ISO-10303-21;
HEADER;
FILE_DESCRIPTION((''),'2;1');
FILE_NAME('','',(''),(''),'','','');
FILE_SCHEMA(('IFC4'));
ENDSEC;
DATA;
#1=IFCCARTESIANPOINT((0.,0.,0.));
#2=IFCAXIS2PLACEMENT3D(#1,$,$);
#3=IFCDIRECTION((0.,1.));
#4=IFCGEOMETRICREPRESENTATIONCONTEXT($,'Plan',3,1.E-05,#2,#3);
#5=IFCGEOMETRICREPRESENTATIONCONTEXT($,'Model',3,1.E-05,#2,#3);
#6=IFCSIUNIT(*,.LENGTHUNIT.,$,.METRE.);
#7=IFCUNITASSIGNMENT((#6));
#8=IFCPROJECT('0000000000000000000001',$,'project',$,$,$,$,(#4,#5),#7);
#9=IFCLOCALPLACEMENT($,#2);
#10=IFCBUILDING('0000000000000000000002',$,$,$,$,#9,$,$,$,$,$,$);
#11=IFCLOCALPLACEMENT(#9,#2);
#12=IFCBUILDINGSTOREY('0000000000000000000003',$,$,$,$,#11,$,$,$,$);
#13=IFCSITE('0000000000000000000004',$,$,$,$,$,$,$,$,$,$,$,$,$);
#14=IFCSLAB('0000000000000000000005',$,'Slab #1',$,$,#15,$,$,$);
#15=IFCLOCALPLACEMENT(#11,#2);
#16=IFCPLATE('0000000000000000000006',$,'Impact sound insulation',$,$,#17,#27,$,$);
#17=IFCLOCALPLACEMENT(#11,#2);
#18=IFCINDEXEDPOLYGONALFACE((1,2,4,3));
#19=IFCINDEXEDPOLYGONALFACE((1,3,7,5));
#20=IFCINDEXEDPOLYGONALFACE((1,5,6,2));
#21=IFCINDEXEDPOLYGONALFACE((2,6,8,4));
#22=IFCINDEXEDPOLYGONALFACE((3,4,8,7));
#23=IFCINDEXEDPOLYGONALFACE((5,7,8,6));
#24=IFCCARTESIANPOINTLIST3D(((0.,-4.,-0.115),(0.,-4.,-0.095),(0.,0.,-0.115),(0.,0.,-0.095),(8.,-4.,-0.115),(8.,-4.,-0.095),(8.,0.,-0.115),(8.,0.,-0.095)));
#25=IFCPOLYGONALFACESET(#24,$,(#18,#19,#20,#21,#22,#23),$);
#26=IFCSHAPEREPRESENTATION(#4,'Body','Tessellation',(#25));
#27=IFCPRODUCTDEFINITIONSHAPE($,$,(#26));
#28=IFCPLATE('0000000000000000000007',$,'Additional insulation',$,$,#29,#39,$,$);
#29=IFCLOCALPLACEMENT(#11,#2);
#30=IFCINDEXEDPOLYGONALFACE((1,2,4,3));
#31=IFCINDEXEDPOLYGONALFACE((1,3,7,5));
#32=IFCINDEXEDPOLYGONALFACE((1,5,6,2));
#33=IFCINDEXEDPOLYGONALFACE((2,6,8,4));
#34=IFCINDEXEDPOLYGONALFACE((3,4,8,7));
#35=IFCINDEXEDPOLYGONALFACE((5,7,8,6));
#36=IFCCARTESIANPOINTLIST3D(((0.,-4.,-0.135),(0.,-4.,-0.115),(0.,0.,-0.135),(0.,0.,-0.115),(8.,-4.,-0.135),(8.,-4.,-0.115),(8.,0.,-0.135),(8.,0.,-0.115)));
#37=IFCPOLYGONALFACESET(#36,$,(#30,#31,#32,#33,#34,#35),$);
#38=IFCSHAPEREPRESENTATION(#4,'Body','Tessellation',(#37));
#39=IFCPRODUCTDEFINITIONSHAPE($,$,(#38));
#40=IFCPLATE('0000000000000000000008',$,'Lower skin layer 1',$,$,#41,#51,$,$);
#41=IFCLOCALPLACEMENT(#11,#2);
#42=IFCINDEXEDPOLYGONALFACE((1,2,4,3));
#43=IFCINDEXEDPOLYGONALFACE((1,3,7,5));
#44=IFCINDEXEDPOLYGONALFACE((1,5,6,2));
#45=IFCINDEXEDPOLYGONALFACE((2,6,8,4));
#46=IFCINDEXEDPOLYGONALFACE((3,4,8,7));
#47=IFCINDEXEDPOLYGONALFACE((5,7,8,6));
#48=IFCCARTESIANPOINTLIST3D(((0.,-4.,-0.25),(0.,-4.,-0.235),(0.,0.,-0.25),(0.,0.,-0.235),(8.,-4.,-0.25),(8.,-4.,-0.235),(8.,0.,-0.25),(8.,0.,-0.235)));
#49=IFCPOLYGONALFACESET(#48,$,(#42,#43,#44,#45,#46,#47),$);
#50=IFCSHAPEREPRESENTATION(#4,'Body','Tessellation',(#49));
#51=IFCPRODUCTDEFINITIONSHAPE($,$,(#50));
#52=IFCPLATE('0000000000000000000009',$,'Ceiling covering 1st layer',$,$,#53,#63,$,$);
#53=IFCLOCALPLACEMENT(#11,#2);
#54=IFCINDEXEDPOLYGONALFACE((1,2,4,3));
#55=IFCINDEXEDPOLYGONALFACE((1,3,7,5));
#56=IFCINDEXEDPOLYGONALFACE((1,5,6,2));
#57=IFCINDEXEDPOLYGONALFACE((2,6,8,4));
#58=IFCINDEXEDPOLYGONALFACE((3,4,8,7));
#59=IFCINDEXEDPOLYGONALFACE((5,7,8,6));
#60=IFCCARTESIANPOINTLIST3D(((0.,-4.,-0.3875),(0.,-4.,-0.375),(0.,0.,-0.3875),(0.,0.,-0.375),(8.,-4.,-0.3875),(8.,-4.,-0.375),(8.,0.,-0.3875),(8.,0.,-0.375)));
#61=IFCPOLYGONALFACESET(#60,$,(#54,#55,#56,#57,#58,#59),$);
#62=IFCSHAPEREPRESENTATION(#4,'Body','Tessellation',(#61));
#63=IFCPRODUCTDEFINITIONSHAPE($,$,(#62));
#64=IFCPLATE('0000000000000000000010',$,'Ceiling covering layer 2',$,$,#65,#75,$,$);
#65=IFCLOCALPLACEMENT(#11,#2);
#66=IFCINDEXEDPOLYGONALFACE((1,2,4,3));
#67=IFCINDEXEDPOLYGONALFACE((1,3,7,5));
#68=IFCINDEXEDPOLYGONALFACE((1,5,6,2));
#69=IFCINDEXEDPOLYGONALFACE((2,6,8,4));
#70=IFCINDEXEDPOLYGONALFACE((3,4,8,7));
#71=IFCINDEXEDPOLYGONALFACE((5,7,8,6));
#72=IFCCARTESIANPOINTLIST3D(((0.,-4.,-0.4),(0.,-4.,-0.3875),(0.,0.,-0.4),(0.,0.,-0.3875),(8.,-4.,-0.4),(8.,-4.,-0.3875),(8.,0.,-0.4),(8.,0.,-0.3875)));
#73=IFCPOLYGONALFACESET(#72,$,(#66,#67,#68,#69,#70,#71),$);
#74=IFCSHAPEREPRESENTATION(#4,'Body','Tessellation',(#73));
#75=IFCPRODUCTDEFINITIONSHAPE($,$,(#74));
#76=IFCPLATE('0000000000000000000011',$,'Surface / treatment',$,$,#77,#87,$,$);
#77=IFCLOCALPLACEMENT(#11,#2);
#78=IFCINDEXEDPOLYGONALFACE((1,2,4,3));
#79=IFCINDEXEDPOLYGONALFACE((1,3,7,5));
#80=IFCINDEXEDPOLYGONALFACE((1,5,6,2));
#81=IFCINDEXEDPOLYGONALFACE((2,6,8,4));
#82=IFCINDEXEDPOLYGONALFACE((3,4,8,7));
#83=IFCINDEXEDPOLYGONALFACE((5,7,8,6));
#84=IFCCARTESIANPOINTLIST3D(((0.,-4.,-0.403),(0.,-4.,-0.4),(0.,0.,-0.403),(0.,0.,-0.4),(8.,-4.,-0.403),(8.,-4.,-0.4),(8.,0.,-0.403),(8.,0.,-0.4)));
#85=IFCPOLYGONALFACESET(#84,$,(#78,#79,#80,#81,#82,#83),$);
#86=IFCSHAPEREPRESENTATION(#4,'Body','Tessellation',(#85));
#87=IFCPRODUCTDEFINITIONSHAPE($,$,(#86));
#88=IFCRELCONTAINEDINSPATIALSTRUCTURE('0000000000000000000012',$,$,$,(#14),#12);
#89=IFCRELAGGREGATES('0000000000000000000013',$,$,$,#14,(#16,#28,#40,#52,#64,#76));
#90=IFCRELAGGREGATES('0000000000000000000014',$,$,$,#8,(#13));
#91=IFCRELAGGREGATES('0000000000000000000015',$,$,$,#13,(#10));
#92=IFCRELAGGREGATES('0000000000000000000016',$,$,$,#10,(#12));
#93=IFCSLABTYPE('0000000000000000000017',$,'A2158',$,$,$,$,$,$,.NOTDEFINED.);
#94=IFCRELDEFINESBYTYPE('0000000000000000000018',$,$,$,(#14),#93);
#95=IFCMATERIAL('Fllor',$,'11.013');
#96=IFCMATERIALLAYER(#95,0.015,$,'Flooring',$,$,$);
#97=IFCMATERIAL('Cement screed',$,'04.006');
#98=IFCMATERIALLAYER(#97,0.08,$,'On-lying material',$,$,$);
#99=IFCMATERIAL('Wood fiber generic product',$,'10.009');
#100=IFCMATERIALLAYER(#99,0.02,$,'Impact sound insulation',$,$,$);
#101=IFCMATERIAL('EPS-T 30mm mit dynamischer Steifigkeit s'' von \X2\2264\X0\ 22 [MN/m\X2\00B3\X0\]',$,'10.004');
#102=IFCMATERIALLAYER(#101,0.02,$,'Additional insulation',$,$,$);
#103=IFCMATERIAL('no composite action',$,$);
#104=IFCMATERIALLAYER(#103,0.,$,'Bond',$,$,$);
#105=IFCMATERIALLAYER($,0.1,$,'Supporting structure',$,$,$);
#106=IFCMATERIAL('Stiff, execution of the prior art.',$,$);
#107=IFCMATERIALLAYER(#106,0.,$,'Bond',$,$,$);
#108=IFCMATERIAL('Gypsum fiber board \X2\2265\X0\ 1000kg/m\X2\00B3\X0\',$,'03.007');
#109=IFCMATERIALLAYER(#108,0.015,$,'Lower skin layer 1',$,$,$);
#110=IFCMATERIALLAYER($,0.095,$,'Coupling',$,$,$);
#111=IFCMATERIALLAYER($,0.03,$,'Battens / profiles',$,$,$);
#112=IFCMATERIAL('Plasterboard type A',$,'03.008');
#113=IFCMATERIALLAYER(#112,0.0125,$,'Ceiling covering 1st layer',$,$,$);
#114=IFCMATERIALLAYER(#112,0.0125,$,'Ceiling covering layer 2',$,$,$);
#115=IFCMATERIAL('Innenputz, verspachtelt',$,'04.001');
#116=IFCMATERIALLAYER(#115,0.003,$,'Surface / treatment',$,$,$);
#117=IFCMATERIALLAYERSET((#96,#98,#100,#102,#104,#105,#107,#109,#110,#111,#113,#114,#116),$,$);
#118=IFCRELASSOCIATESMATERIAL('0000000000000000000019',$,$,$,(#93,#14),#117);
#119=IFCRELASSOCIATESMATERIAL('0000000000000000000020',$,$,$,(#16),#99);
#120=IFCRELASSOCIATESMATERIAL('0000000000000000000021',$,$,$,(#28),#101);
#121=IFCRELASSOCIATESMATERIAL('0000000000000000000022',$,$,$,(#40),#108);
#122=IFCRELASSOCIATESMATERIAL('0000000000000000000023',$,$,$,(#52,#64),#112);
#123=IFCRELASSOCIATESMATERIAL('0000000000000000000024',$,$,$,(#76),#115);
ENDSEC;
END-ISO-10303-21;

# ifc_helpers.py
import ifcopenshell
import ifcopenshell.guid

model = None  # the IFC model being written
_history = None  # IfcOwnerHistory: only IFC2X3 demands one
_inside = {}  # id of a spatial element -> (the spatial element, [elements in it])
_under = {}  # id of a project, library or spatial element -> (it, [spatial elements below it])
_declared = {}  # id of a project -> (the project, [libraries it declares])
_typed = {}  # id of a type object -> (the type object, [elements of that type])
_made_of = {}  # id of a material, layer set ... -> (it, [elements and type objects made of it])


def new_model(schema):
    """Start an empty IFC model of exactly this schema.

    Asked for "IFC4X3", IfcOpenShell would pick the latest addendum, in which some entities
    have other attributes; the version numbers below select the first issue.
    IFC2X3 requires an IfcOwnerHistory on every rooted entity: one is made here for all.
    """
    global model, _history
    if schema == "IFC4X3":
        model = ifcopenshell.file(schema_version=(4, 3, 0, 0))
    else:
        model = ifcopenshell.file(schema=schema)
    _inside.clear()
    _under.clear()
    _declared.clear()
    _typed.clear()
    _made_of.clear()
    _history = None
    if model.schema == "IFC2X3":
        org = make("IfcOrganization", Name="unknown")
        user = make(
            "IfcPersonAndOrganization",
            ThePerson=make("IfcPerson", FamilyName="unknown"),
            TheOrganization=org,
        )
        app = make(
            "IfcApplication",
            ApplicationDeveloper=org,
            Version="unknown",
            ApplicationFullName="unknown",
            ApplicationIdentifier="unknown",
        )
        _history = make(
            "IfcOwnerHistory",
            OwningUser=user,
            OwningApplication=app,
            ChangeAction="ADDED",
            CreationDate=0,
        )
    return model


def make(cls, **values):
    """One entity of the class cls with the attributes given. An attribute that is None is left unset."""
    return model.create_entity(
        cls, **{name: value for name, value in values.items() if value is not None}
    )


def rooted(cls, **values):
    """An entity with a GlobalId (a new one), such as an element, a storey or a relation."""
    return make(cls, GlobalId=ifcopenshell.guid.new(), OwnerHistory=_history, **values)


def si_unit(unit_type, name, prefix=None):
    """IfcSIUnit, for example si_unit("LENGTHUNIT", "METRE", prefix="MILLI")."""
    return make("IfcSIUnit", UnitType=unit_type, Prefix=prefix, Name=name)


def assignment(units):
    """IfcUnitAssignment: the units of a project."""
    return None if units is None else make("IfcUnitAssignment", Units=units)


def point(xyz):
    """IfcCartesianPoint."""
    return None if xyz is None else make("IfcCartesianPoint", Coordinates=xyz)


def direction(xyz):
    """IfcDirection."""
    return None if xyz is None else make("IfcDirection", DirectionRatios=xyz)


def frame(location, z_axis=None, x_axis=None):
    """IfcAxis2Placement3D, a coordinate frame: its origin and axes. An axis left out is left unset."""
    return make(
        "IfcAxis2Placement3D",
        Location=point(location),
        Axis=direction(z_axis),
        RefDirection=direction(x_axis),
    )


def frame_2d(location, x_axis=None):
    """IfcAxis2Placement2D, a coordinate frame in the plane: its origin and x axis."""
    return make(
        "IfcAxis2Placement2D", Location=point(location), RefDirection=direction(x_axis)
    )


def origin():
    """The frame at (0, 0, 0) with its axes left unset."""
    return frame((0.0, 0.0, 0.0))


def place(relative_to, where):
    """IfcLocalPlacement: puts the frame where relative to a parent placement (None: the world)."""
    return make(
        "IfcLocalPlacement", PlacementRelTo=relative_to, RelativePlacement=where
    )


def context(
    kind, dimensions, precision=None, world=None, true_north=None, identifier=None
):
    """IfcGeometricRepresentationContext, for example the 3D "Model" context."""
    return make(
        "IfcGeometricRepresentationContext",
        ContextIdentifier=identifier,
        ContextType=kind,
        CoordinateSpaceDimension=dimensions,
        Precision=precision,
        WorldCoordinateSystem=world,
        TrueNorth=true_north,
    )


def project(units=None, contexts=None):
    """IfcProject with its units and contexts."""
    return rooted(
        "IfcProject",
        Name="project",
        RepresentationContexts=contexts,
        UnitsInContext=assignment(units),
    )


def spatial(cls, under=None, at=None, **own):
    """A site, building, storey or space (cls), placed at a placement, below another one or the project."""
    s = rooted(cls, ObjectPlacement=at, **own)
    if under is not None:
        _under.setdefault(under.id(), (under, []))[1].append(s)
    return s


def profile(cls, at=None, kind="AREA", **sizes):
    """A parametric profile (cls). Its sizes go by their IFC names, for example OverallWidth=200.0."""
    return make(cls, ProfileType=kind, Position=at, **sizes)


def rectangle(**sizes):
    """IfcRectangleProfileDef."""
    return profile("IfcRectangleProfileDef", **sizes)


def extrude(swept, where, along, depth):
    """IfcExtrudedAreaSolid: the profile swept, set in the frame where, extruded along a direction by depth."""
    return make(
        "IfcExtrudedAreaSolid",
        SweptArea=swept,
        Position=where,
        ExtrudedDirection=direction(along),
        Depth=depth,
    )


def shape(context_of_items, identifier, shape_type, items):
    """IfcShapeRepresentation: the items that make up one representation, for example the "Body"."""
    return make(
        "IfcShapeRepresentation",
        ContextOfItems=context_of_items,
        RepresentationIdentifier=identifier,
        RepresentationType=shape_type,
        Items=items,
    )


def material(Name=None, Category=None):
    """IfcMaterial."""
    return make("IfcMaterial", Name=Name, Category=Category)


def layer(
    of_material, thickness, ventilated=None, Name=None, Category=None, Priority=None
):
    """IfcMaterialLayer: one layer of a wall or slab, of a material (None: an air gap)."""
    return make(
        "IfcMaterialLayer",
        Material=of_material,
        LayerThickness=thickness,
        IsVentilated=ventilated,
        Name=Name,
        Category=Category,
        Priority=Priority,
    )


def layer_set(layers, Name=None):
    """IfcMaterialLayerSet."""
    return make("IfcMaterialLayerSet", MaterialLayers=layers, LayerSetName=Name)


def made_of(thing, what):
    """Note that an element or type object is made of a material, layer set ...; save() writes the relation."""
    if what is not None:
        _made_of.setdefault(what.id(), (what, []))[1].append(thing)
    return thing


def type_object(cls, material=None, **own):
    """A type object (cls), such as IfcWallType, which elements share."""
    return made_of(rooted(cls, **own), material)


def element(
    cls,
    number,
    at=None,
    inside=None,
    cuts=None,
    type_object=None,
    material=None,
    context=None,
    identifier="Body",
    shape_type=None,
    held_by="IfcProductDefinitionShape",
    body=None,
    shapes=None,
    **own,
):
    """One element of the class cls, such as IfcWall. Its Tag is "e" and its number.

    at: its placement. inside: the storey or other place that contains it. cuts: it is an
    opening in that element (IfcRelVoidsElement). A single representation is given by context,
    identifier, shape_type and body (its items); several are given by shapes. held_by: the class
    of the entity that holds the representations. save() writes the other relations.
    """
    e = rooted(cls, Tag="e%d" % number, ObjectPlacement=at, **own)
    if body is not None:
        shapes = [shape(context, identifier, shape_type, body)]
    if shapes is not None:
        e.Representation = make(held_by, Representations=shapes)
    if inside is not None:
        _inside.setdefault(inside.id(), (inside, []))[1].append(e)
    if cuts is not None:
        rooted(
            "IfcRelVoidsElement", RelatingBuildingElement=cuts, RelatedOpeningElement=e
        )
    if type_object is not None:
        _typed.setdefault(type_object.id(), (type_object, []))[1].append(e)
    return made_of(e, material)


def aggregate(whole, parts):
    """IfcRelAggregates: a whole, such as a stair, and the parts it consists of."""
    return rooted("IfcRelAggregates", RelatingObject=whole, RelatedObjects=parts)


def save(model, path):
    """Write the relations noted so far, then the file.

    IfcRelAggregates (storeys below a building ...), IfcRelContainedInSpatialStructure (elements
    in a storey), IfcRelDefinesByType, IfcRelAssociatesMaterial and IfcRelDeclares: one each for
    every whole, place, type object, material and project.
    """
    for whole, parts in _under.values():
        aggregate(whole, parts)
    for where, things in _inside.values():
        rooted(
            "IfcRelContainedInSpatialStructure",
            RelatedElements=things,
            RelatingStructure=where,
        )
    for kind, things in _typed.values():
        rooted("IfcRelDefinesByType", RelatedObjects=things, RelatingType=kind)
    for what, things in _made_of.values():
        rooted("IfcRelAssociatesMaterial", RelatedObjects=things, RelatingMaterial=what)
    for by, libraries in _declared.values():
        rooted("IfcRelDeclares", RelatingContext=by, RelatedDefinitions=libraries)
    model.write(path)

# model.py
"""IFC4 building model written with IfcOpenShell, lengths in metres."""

from ifc_helpers import new_model, si_unit, direction, frame, frame_2d, origin, place, context, project, spatial, rectangle, extrude, material, layer, layer_set, type_object, element, aggregate, save


model = new_model("IFC4")

# Units and contexts
plan_context = context("Plan", 3, precision=1e-05, world=origin(), true_north=direction((0.0, 1.0)))
model_context = context("Model", 3, precision=1e-05, world=origin(), true_north=direction((0.0, 1.0)))
ifc_project = project(units=[si_unit("LENGTHUNIT", "METRE")], contexts=[plan_context, model_context])

# Site, building, storey
site = spatial("IfcSite", under=ifc_project)
building_placement = place(None, origin())
building = spatial("IfcBuilding", under=site, at=building_placement)
storey_placement = place(building_placement, origin())
storey = spatial("IfcBuildingStorey", under=building, at=storey_placement)

# Slab, plates
ifc_material_1 = material(Name="Fllor", Category="11.013")
ifc_layer_1 = layer(ifc_material_1, 0.015, Name="Flooring")
ifc_material_2 = material(Name="Cement screed", Category="04.006")
ifc_layer_2 = layer(ifc_material_2, 0.08, Name="On-lying material")
ifc_material_3 = material(Name="Wood fiber generic product", Category="10.009")
ifc_layer_3 = layer(ifc_material_3, 0.02, Name="Impact sound insulation")
ifc_material_4 = material(Name="EPS-T 30mm mit dynamischer Steifigkeit s' von ≤ 22 [MN/m³]", Category="10.004")
ifc_layer_4 = layer(ifc_material_4, 0.02, Name="Additional insulation")
ifc_material_5 = material(Name="no composite action")
ifc_layer_5 = layer(ifc_material_5, 0.0, Name="Bond")
ifc_layer_6 = layer(None, 0.1, Name="Supporting structure")
ifc_material_6 = material(Name="Stiff, execution of the prior art.")
ifc_layer_7 = layer(ifc_material_6, 0.0, Name="Bond")
ifc_material_7 = material(Name="Gypsum fiber board ≥ 1000kg/m³", Category="03.007")
ifc_layer_8 = layer(ifc_material_7, 0.015, Name="Lower skin layer 1")
ifc_layer_9 = layer(None, 0.095, Name="Coupling")
ifc_layer_10 = layer(None, 0.03, Name="Battens / profiles")
ifc_material_8 = material(Name="Plasterboard type A", Category="03.008")
ifc_layer_11 = layer(ifc_material_8, 0.0125, Name="Ceiling covering 1st layer")
ifc_layer_12 = layer(ifc_material_8, 0.0125, Name="Ceiling covering layer 2")
ifc_material_9 = material(Name="Innenputz, verspachtelt", Category="04.001")
ifc_layer_13 = layer(ifc_material_9, 0.003, Name="Surface / treatment")
ifc_layer_set = layer_set([ifc_layer_1, ifc_layer_2, ifc_layer_3, ifc_layer_4, ifc_layer_5, ifc_layer_6, ifc_layer_7, ifc_layer_8, ifc_layer_9, ifc_layer_10, ifc_layer_11, ifc_layer_12, ifc_layer_13])
slab_type = type_object("IfcSlabType", Name="A2158", PredefinedType="NOTDEFINED", material=ifc_layer_set)
slab_placement = place(None, frame((0.0, 0.0, 0.0), z_axis=(0.0, 0.0, -1.0), x_axis=(1.0, 0.0, 0.0)))
slab = element("IfcSlab", 1, at=slab_placement, inside=storey, type_object=slab_type, material=ifc_layer_set, Name="Slab #1")
plate_1_placement = place(slab_placement, origin())
plate_1 = element("IfcPlate", 2, at=plate_1_placement, material=ifc_material_3, Name="Impact sound insulation", context=plan_context, shape_type="SweptSolid", body=[
    extrude(rectangle(XDim=8.0, YDim=4.0, at=frame_2d((4.0, 2.0), x_axis=(1.0, 0.0))), frame((0.0, 0.0, 0.095), z_axis=(0.0, 0.0, 1.0), x_axis=(1.0, 0.0, 0.0)), (0.0, 0.0, 1.0), 0.02),
])
plate_2_placement = place(slab_placement, origin())
plate_2 = element("IfcPlate", 3, at=plate_2_placement, material=ifc_material_4, Name="Additional insulation", context=plan_context, shape_type="SweptSolid", body=[
    extrude(rectangle(XDim=8.0, YDim=4.0, at=frame_2d((4.0, 2.0), x_axis=(1.0, 0.0))), frame((0.0, 0.0, 0.115), z_axis=(0.0, 0.0, 1.0), x_axis=(1.0, 0.0, 0.0)), (0.0, 0.0, 1.0), 0.02),
])
plate_3_placement = place(slab_placement, origin())
plate_3 = element("IfcPlate", 4, at=plate_3_placement, material=ifc_material_7, Name="Lower skin layer 1", context=plan_context, shape_type="SweptSolid", body=[
    extrude(rectangle(XDim=8.0, YDim=4.0, at=frame_2d((4.0, 2.0), x_axis=(1.0, 0.0))), frame((0.0, 0.0, 0.235), z_axis=(0.0, 0.0, 1.0), x_axis=(1.0, 0.0, 0.0)), (0.0, 0.0, 1.0), 0.015),
])
plate_4_placement = place(slab_placement, origin())
plate_4 = element("IfcPlate", 5, at=plate_4_placement, material=ifc_material_8, Name="Ceiling covering 1st layer", context=plan_context, shape_type="SweptSolid", body=[
    extrude(rectangle(XDim=8.0, YDim=4.0, at=frame_2d((4.0, 2.0), x_axis=(1.0, 0.0))), frame((0.0, 0.0, 0.375), z_axis=(0.0, 0.0, 1.0), x_axis=(1.0, 0.0, 0.0)), (0.0, 0.0, 1.0), 0.0125),
])
plate_5_placement = place(slab_placement, origin())
plate_5 = element("IfcPlate", 6, at=plate_5_placement, material=ifc_material_8, Name="Ceiling covering layer 2", context=plan_context, shape_type="SweptSolid", body=[
    extrude(rectangle(XDim=8.0, YDim=4.0, at=frame_2d((4.0, 2.0), x_axis=(1.0, 0.0))), frame((0.0, 0.0, 0.3875), z_axis=(0.0, 0.0, 1.0), x_axis=(1.0, 0.0, 0.0)), (0.0, 0.0, 1.0), 0.0125),
])
plate_6_placement = place(slab_placement, origin())
plate_6 = element("IfcPlate", 7, at=plate_6_placement, material=ifc_material_9, Name="Surface / treatment", context=plan_context, shape_type="SweptSolid", body=[
    extrude(rectangle(XDim=8.0, YDim=4.0, at=frame_2d((4.0, 2.0), x_axis=(1.0, 0.0))), frame((0.0, 0.0, 0.4), z_axis=(0.0, 0.0, 1.0), x_axis=(1.0, 0.0, 0.0)), (0.0, 0.0, 1.0), 0.003),
])
aggregate(slab, [plate_1, plate_2, plate_3, plate_4, plate_5, plate_6])

save(model, "model.ifc")
